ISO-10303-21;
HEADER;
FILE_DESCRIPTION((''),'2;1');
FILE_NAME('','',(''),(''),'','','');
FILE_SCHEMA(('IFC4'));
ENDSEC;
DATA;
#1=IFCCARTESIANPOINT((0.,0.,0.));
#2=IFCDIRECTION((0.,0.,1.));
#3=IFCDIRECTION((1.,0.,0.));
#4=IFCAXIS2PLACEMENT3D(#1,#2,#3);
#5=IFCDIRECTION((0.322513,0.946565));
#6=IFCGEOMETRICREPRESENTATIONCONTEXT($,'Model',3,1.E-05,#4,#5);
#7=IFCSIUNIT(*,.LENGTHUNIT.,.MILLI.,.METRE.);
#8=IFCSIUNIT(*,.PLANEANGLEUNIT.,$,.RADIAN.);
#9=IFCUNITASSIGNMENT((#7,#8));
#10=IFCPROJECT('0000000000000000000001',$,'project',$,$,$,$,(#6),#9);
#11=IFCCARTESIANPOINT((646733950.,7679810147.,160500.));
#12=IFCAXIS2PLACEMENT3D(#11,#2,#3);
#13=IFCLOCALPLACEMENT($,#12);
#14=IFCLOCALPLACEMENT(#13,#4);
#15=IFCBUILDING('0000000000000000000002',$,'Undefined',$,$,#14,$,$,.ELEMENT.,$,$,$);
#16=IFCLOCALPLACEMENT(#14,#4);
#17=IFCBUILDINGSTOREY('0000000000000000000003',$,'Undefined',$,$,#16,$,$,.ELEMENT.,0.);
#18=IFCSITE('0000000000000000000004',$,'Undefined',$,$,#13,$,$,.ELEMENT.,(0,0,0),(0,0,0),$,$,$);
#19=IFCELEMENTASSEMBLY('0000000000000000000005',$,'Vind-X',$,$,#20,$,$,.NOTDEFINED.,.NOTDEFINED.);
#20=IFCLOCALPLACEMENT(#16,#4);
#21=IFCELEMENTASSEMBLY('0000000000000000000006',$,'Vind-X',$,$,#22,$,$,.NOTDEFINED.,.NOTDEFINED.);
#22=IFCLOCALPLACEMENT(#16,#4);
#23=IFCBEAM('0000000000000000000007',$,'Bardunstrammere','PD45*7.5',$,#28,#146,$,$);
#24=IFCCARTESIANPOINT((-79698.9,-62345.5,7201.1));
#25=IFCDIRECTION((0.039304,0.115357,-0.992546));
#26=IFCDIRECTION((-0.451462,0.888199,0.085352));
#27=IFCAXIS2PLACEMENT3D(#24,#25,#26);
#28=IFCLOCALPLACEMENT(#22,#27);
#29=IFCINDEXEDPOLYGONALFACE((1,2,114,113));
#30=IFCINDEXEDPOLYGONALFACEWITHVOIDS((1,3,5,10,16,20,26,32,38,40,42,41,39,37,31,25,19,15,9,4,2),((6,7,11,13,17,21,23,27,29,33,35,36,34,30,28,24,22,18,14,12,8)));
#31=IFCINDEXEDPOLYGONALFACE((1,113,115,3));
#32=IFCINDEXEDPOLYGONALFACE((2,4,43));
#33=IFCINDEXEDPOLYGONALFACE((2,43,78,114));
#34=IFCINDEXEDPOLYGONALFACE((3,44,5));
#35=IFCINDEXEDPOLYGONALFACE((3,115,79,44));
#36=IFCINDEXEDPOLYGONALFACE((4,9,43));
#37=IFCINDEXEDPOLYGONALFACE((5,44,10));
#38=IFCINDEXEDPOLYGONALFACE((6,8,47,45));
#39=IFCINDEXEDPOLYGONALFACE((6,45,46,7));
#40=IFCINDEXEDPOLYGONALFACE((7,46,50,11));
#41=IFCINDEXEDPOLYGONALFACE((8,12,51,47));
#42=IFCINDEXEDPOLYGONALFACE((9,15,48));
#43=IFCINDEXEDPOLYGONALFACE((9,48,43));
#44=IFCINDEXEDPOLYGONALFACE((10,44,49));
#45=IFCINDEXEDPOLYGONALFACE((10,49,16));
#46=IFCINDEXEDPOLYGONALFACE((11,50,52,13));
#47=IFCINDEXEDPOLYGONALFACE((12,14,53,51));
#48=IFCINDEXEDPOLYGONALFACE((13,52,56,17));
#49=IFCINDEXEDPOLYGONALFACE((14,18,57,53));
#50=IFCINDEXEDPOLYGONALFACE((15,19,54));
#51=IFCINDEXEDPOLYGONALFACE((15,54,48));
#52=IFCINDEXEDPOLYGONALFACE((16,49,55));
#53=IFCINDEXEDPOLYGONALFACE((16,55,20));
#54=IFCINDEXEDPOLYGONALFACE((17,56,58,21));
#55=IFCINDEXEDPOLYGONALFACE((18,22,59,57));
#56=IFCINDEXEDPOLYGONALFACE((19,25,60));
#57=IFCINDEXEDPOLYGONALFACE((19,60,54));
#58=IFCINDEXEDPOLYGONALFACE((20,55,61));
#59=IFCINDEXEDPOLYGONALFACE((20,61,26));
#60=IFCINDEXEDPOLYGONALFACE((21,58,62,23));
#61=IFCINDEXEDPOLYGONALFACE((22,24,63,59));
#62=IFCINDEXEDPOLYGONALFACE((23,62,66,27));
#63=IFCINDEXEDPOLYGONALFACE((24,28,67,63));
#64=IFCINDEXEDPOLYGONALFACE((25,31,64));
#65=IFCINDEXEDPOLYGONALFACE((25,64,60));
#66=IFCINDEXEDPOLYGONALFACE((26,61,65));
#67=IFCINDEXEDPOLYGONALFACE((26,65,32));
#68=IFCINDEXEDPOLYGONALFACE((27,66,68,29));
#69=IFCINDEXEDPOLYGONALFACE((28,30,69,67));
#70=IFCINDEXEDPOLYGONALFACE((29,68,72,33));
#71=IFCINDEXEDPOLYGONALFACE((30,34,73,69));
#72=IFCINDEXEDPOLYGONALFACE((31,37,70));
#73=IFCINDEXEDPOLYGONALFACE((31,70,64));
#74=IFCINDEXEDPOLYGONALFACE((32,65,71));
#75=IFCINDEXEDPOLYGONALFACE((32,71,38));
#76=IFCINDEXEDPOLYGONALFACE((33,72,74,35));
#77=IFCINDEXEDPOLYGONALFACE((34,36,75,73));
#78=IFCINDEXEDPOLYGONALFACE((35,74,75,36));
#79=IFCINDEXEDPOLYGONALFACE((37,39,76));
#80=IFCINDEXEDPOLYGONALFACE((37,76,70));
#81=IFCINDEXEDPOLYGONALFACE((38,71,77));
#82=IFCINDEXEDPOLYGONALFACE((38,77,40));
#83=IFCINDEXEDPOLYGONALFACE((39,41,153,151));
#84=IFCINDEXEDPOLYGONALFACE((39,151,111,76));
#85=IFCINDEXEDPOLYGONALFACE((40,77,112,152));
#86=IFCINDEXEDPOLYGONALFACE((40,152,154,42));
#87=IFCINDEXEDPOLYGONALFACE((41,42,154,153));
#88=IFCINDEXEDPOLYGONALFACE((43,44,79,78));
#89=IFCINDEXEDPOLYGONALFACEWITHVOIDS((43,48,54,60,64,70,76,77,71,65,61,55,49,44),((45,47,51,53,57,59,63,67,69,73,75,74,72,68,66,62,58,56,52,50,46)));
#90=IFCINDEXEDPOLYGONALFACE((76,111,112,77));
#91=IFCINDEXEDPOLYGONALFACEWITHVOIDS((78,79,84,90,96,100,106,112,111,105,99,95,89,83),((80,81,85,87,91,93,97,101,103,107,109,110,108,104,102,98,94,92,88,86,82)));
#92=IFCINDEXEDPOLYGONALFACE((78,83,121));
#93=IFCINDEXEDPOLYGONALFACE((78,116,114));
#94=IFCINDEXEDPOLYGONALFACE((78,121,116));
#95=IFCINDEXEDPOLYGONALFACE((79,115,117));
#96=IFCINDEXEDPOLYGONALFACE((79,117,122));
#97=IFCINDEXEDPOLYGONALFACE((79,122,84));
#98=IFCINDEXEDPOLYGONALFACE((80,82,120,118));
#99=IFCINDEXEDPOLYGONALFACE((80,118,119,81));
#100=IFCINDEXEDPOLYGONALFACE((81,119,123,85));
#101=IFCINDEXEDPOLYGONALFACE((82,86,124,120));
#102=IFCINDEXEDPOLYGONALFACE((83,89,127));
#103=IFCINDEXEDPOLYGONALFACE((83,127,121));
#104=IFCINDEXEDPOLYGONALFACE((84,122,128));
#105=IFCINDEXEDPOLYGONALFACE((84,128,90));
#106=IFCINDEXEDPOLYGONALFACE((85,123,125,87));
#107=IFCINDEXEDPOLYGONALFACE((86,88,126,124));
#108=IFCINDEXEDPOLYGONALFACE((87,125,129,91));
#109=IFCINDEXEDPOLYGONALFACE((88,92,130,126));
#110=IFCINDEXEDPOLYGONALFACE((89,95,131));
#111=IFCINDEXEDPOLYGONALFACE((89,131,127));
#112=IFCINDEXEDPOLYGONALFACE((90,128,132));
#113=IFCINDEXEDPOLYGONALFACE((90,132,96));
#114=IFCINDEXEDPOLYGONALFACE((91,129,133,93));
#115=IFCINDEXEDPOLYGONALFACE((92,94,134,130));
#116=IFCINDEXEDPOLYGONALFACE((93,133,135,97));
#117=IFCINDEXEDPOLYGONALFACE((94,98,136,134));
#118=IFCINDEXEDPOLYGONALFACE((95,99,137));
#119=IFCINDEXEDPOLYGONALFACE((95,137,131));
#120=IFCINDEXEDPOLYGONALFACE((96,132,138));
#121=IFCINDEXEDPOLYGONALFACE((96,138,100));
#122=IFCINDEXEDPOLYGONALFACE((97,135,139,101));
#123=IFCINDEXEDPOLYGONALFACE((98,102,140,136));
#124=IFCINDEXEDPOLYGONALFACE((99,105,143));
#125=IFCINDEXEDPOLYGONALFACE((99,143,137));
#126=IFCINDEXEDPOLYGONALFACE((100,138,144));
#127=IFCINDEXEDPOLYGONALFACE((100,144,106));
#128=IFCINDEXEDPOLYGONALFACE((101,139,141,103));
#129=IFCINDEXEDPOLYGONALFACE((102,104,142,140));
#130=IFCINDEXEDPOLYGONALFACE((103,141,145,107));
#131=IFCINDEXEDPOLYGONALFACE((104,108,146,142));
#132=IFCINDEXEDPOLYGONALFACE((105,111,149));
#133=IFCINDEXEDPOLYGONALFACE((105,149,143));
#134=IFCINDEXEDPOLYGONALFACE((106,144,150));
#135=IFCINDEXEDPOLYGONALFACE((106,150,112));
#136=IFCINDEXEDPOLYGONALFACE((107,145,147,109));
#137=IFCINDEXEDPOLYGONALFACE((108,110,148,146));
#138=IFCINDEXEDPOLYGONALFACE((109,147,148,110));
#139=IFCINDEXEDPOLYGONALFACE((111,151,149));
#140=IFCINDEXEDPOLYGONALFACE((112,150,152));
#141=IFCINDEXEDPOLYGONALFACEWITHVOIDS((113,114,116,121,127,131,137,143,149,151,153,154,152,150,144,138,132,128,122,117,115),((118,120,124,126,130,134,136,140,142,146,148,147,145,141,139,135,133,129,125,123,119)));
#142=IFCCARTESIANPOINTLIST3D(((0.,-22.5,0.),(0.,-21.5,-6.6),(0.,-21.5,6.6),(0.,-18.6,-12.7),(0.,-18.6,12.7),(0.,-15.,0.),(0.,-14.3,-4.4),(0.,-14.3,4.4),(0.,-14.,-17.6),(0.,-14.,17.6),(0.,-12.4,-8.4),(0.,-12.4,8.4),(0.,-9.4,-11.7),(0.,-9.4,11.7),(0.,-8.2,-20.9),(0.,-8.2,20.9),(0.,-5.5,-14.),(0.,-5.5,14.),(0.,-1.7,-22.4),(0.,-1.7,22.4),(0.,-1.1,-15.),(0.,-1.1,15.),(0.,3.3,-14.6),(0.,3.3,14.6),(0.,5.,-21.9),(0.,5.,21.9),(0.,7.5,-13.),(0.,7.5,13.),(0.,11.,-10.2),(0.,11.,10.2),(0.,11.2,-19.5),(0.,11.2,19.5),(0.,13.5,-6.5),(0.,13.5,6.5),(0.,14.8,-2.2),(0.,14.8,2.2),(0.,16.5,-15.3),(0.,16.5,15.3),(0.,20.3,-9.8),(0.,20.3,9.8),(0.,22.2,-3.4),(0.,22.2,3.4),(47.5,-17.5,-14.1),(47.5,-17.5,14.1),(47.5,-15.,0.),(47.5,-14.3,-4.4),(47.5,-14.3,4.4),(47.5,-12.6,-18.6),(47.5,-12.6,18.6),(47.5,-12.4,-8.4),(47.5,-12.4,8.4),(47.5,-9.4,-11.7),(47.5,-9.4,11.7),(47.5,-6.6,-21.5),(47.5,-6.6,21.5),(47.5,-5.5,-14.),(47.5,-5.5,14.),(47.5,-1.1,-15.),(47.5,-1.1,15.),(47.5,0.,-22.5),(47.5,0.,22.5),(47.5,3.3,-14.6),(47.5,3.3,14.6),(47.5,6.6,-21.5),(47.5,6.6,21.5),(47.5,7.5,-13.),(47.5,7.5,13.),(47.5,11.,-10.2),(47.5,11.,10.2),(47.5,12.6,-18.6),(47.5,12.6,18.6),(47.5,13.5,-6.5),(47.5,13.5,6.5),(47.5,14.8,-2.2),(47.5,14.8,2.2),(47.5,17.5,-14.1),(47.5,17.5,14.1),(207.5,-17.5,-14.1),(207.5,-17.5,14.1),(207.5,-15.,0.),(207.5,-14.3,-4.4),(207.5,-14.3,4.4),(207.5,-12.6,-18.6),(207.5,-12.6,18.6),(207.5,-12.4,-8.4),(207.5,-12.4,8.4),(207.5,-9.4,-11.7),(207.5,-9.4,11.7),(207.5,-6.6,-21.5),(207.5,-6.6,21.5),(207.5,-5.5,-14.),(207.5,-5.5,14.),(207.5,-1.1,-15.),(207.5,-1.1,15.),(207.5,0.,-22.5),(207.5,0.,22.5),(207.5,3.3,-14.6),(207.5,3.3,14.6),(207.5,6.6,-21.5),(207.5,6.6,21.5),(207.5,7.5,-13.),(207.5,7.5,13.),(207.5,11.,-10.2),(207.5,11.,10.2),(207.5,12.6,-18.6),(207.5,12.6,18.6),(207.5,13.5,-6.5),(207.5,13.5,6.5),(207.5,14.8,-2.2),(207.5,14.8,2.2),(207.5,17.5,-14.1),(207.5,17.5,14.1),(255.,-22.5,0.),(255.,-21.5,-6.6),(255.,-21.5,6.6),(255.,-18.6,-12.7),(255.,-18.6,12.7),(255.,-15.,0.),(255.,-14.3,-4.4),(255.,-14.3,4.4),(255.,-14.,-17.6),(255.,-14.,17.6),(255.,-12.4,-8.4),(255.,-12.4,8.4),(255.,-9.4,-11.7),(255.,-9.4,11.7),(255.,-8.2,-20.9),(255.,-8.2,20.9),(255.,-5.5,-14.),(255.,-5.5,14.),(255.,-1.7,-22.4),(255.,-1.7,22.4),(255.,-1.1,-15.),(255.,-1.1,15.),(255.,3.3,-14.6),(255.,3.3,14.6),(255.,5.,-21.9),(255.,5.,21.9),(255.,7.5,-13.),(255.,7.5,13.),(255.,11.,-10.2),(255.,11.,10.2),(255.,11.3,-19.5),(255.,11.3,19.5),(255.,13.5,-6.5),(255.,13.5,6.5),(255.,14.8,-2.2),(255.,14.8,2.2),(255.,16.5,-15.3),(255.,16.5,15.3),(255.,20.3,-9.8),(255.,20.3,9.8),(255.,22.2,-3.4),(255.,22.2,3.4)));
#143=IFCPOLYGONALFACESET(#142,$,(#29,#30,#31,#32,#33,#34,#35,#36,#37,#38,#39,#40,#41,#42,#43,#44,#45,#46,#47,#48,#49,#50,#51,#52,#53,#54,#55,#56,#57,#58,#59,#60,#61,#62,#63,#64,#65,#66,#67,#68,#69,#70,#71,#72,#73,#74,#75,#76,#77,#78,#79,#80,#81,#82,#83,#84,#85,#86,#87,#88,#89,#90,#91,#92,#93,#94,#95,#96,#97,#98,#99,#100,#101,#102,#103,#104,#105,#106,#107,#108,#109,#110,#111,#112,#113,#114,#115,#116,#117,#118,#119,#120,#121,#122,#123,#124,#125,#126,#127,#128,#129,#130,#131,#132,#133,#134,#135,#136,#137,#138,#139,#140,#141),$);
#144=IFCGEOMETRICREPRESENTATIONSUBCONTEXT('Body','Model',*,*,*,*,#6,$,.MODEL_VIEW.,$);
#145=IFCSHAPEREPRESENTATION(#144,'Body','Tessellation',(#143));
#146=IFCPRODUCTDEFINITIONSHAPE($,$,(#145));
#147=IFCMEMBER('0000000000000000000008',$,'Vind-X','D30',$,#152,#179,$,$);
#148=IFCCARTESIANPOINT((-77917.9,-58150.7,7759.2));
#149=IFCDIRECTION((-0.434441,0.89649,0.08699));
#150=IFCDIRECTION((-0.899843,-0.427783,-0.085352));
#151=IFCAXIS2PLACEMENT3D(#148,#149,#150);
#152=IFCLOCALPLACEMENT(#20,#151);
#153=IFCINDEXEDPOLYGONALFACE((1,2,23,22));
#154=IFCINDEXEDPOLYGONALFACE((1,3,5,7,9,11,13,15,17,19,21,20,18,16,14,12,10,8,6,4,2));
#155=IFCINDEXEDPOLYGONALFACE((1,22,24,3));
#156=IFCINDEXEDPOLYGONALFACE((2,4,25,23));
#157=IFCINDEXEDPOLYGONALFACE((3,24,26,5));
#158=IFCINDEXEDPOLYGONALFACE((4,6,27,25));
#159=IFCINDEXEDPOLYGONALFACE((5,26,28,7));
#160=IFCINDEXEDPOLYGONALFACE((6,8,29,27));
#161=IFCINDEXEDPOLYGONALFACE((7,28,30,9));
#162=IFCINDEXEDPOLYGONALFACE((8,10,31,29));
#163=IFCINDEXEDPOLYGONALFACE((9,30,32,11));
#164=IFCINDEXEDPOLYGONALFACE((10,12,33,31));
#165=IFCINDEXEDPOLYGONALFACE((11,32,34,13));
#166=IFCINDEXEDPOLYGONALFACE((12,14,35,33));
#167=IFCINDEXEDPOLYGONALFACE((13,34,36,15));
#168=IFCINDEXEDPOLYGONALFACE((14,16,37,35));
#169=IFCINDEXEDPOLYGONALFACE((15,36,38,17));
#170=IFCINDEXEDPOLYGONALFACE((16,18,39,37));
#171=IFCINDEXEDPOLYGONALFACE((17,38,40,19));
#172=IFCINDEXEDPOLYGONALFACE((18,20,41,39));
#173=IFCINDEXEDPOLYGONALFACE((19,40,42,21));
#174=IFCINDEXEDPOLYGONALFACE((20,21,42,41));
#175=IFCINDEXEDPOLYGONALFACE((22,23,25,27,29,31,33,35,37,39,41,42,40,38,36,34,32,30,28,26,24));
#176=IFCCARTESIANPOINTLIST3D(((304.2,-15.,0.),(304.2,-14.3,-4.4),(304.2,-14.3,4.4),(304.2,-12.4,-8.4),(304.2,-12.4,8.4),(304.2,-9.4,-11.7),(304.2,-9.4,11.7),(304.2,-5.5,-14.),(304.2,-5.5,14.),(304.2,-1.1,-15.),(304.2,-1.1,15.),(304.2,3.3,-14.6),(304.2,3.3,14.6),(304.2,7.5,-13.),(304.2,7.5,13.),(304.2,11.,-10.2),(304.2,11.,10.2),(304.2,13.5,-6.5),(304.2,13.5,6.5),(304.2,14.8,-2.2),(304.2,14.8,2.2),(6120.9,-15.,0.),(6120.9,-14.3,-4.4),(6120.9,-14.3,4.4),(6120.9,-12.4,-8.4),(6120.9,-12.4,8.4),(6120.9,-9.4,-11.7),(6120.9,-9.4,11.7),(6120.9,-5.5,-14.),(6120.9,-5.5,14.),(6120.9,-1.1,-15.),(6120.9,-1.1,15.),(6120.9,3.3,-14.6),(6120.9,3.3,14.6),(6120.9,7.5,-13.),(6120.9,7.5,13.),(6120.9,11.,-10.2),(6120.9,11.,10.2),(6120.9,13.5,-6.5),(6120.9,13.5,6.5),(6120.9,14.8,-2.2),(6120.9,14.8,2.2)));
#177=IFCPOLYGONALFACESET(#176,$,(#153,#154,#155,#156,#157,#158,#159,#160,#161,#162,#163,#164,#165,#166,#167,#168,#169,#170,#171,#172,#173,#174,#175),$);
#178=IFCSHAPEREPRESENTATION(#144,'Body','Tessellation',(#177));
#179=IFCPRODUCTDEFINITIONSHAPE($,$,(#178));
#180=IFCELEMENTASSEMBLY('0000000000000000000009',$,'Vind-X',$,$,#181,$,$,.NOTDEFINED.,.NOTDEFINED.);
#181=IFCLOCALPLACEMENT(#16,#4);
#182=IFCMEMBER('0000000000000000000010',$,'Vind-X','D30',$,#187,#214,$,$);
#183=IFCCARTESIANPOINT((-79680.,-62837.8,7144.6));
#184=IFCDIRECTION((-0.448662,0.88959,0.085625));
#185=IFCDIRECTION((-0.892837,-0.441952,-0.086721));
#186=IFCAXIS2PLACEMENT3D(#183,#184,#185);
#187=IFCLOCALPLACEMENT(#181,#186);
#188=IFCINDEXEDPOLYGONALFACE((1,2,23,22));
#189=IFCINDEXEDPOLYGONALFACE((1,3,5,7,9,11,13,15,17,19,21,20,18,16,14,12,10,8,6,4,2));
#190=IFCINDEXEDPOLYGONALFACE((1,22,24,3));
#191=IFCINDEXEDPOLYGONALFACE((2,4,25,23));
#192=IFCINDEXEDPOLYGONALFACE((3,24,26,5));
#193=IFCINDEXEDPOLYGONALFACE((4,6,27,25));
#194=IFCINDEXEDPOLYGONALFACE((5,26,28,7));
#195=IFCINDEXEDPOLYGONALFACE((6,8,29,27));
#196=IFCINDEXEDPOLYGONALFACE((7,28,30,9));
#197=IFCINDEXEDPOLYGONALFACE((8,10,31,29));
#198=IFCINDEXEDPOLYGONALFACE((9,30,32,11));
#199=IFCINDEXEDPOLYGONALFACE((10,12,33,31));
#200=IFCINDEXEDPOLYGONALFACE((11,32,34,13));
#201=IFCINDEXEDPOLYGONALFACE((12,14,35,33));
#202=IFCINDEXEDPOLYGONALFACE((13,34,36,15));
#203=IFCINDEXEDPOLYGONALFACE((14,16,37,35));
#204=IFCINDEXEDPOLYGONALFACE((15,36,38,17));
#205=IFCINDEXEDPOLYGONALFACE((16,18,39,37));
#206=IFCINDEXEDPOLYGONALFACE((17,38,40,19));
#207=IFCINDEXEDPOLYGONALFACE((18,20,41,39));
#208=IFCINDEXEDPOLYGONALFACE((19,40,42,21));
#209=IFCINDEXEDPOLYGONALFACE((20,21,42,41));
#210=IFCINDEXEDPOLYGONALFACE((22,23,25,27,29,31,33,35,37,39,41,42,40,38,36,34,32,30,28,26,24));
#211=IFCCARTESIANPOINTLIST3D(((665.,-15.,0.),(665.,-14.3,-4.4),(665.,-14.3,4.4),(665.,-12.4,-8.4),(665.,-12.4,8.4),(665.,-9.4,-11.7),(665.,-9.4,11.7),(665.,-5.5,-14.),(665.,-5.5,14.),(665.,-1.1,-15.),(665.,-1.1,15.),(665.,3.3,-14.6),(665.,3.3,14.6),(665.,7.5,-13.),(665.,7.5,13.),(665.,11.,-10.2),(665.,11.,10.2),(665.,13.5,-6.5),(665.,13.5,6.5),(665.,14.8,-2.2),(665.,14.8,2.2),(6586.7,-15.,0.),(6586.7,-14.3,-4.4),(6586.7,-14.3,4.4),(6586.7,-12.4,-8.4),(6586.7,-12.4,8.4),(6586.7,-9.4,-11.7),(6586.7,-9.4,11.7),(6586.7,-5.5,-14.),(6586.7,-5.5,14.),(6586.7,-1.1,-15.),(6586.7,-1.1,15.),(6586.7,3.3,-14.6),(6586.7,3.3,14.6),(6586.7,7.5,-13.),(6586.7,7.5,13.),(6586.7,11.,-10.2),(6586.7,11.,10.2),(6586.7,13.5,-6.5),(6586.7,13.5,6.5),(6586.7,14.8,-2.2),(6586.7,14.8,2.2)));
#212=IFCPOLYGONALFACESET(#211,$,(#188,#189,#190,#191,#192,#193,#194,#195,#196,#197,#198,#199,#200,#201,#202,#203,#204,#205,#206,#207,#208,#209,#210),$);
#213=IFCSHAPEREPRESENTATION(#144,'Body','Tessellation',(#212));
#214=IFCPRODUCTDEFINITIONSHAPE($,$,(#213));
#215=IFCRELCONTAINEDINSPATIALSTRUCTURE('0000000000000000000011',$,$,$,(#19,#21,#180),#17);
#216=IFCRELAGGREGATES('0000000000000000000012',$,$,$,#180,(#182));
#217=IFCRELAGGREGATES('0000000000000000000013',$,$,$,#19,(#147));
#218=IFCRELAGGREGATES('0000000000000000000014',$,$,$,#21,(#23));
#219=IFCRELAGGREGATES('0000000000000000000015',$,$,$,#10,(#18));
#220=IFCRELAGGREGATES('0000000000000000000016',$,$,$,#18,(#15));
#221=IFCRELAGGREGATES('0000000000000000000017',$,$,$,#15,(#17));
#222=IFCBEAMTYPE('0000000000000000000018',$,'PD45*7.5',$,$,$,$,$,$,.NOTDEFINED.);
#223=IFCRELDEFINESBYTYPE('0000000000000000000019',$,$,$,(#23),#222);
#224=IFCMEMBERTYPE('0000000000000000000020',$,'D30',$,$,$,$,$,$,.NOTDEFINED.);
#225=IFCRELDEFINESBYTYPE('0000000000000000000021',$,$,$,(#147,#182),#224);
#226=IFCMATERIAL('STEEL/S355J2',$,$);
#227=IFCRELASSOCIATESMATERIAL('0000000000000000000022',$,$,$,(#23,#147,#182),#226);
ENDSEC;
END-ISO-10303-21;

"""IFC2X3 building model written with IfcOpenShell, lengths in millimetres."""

from ifc_helpers import new_model, si_unit, direction, frame, origin_with_axes, origin_2d_with_axis, place, context, subcontext, project, spatial, rectangle, circle, hollow_circle, extrude, boolean, clip, halfspace, material, type_object, element, aggregate, save


model = new_model("IFC2X3")

# Units and contexts
model_context = context("Model", 3, precision=1e-05, world=origin_with_axes(), true_north=direction((0.322513, 0.946565)))
body_context = subcontext(model_context, "Body", "Model", "MODEL_VIEW")
ifc_project = project(units=[si_unit("LENGTHUNIT", "METRE", prefix="MILLI"), si_unit("PLANEANGLEUNIT", "RADIAN")], contexts=[model_context])

# Site, building, storey
site_placement = place(None, frame((646733950.0, 7679810147.0, 160500.0), z_axis=(0.0, 0.0, 1.0), x_axis=(1.0, 0.0, 0.0)))
site = spatial("IfcSite", under=ifc_project, at=site_placement, Name="Undefined", CompositionType="ELEMENT", RefLatitude=(0, 0, 0), RefLongitude=(0, 0, 0))
building_placement = place(site_placement, origin_with_axes())
building = spatial("IfcBuilding", under=site, at=building_placement, Name="Undefined", CompositionType="ELEMENT")
storey_placement = place(building_placement, origin_with_axes())
storey = spatial("IfcBuildingStorey", under=building, at=storey_placement, Name="Undefined", CompositionType="ELEMENT", Elevation=0.0)

# Element assemblies, beam
assembly_1_placement = place(storey_placement, origin_with_axes())
assembly_1 = element("IfcElementAssembly", 1, at=assembly_1_placement, inside=storey, Name="Vind-X", AssemblyPlace="NOTDEFINED", PredefinedType="NOTDEFINED")
ifc_material_1 = material(Name="STEEL/S355J2")
beam_type_1 = type_object("IfcBeamType", Name="PD45*7.5", PredefinedType="NOTDEFINED")
assembly_2_placement = place(storey_placement, origin_with_axes())
assembly_2 = element("IfcElementAssembly", 2, at=assembly_2_placement, inside=storey, Name="Vind-X", AssemblyPlace="NOTDEFINED", PredefinedType="NOTDEFINED")
beam_1_placement = place(assembly_2_placement, frame((-79698.9, -62345.5, 7201.1), z_axis=(0.039304, 0.115357, -0.992546), x_axis=(-0.451462, 0.888199, 0.085352)))
beam_1 = element("IfcBeam", 3, at=beam_1_placement, type_object=beam_type_1, material=ifc_material_1, Name="Bardunstrammere", Description="PD45*7.5", context=body_context, shape_type="CSG", body=[
    boolean("DIFFERENCE", extrude(hollow_circle(Radius=22.5, WallThickness=7.5, at=origin_2d_with_axis()), frame((255.0, 0.0, 0.0), z_axis=(-1.0, 0.0, 0.0), x_axis=(0.0, -1.0, 0.0)), (0.0, 0.0, 1.0), 255.0), extrude(rectangle(XDim=35.0, YDim=90.0, at=origin_2d_with_axis()), frame((207.5, 0.0, 0.0), z_axis=(-1.0, 0.0, 0.0), x_axis=(0.0, -1.0, 0.0)), (0.0, 0.0, 1.0), 160.0)),
])

# Member
member_type = type_object("IfcMemberType", Name="D30", PredefinedType="NOTDEFINED")
member_1_placement = place(assembly_1_placement, frame((-77917.9, -58150.7, 7759.2), z_axis=(-0.434441, 0.89649, 0.08699), x_axis=(-0.899843, -0.427783, -0.085352)))
member_1 = element("IfcMember", 4, at=member_1_placement, type_object=member_type, material=ifc_material_1, Name="Vind-X", Description="D30", context=body_context, shape_type="Clipping", body=[
    clip(clip(extrude(circle(Radius=15.0, at=origin_2d_with_axis()), frame((6785.9, 0.0, 0.0), z_axis=(-1.0, 0.0, 0.0), x_axis=(0.0, -1.0, 0.0)), (0.0, 0.0, 1.0), 6785.9), halfspace(frame((6120.9, -6.0, 10.2), z_axis=(1.0, 0.0, 0.0), x_axis=(0.0, 1.0, 0.0)), False)), halfspace(frame((304.2, -22.5, 0.0), z_axis=(1.0, 0.0, 0.0), x_axis=(0.0, 0.0, 1.0)), True)),
])

# Element assembly, member
assembly_3_placement = place(storey_placement, origin_with_axes())
assembly_3 = element("IfcElementAssembly", 5, at=assembly_3_placement, inside=storey, Name="Vind-X", AssemblyPlace="NOTDEFINED", PredefinedType="NOTDEFINED")
member_2_placement = place(assembly_3_placement, frame((-79680.0, -62837.8, 7144.6), z_axis=(-0.448662, 0.88959, 0.085625), x_axis=(-0.892837, -0.441952, -0.086721)))
member_2 = element("IfcMember", 6, at=member_2_placement, type_object=member_type, material=ifc_material_1, Name="Vind-X", Description="D30", context=body_context, shape_type="Clipping", body=[
    clip(clip(extrude(circle(Radius=15.0, at=origin_2d_with_axis()), frame((6671.7, 0.0, 0.0), z_axis=(-1.0, 0.0, 0.0), x_axis=(0.0, -1.0, 0.0)), (0.0, 0.0, 1.0), 6671.7), halfspace(frame((6586.7, 6.0, 16.0), z_axis=(-1.0, 0.0, 0.0), x_axis=(0.0, -1.0, 0.0)), True)), halfspace(frame((665.0, 6.0, 10.2), z_axis=(-1.0, 0.0, 0.0), x_axis=(0.0, -1.0, 0.0)), False)),
])

aggregate(assembly_3, [member_2])

aggregate(assembly_1, [member_1])
aggregate(assembly_2, [beam_1])

save(model, "model.ifc")
